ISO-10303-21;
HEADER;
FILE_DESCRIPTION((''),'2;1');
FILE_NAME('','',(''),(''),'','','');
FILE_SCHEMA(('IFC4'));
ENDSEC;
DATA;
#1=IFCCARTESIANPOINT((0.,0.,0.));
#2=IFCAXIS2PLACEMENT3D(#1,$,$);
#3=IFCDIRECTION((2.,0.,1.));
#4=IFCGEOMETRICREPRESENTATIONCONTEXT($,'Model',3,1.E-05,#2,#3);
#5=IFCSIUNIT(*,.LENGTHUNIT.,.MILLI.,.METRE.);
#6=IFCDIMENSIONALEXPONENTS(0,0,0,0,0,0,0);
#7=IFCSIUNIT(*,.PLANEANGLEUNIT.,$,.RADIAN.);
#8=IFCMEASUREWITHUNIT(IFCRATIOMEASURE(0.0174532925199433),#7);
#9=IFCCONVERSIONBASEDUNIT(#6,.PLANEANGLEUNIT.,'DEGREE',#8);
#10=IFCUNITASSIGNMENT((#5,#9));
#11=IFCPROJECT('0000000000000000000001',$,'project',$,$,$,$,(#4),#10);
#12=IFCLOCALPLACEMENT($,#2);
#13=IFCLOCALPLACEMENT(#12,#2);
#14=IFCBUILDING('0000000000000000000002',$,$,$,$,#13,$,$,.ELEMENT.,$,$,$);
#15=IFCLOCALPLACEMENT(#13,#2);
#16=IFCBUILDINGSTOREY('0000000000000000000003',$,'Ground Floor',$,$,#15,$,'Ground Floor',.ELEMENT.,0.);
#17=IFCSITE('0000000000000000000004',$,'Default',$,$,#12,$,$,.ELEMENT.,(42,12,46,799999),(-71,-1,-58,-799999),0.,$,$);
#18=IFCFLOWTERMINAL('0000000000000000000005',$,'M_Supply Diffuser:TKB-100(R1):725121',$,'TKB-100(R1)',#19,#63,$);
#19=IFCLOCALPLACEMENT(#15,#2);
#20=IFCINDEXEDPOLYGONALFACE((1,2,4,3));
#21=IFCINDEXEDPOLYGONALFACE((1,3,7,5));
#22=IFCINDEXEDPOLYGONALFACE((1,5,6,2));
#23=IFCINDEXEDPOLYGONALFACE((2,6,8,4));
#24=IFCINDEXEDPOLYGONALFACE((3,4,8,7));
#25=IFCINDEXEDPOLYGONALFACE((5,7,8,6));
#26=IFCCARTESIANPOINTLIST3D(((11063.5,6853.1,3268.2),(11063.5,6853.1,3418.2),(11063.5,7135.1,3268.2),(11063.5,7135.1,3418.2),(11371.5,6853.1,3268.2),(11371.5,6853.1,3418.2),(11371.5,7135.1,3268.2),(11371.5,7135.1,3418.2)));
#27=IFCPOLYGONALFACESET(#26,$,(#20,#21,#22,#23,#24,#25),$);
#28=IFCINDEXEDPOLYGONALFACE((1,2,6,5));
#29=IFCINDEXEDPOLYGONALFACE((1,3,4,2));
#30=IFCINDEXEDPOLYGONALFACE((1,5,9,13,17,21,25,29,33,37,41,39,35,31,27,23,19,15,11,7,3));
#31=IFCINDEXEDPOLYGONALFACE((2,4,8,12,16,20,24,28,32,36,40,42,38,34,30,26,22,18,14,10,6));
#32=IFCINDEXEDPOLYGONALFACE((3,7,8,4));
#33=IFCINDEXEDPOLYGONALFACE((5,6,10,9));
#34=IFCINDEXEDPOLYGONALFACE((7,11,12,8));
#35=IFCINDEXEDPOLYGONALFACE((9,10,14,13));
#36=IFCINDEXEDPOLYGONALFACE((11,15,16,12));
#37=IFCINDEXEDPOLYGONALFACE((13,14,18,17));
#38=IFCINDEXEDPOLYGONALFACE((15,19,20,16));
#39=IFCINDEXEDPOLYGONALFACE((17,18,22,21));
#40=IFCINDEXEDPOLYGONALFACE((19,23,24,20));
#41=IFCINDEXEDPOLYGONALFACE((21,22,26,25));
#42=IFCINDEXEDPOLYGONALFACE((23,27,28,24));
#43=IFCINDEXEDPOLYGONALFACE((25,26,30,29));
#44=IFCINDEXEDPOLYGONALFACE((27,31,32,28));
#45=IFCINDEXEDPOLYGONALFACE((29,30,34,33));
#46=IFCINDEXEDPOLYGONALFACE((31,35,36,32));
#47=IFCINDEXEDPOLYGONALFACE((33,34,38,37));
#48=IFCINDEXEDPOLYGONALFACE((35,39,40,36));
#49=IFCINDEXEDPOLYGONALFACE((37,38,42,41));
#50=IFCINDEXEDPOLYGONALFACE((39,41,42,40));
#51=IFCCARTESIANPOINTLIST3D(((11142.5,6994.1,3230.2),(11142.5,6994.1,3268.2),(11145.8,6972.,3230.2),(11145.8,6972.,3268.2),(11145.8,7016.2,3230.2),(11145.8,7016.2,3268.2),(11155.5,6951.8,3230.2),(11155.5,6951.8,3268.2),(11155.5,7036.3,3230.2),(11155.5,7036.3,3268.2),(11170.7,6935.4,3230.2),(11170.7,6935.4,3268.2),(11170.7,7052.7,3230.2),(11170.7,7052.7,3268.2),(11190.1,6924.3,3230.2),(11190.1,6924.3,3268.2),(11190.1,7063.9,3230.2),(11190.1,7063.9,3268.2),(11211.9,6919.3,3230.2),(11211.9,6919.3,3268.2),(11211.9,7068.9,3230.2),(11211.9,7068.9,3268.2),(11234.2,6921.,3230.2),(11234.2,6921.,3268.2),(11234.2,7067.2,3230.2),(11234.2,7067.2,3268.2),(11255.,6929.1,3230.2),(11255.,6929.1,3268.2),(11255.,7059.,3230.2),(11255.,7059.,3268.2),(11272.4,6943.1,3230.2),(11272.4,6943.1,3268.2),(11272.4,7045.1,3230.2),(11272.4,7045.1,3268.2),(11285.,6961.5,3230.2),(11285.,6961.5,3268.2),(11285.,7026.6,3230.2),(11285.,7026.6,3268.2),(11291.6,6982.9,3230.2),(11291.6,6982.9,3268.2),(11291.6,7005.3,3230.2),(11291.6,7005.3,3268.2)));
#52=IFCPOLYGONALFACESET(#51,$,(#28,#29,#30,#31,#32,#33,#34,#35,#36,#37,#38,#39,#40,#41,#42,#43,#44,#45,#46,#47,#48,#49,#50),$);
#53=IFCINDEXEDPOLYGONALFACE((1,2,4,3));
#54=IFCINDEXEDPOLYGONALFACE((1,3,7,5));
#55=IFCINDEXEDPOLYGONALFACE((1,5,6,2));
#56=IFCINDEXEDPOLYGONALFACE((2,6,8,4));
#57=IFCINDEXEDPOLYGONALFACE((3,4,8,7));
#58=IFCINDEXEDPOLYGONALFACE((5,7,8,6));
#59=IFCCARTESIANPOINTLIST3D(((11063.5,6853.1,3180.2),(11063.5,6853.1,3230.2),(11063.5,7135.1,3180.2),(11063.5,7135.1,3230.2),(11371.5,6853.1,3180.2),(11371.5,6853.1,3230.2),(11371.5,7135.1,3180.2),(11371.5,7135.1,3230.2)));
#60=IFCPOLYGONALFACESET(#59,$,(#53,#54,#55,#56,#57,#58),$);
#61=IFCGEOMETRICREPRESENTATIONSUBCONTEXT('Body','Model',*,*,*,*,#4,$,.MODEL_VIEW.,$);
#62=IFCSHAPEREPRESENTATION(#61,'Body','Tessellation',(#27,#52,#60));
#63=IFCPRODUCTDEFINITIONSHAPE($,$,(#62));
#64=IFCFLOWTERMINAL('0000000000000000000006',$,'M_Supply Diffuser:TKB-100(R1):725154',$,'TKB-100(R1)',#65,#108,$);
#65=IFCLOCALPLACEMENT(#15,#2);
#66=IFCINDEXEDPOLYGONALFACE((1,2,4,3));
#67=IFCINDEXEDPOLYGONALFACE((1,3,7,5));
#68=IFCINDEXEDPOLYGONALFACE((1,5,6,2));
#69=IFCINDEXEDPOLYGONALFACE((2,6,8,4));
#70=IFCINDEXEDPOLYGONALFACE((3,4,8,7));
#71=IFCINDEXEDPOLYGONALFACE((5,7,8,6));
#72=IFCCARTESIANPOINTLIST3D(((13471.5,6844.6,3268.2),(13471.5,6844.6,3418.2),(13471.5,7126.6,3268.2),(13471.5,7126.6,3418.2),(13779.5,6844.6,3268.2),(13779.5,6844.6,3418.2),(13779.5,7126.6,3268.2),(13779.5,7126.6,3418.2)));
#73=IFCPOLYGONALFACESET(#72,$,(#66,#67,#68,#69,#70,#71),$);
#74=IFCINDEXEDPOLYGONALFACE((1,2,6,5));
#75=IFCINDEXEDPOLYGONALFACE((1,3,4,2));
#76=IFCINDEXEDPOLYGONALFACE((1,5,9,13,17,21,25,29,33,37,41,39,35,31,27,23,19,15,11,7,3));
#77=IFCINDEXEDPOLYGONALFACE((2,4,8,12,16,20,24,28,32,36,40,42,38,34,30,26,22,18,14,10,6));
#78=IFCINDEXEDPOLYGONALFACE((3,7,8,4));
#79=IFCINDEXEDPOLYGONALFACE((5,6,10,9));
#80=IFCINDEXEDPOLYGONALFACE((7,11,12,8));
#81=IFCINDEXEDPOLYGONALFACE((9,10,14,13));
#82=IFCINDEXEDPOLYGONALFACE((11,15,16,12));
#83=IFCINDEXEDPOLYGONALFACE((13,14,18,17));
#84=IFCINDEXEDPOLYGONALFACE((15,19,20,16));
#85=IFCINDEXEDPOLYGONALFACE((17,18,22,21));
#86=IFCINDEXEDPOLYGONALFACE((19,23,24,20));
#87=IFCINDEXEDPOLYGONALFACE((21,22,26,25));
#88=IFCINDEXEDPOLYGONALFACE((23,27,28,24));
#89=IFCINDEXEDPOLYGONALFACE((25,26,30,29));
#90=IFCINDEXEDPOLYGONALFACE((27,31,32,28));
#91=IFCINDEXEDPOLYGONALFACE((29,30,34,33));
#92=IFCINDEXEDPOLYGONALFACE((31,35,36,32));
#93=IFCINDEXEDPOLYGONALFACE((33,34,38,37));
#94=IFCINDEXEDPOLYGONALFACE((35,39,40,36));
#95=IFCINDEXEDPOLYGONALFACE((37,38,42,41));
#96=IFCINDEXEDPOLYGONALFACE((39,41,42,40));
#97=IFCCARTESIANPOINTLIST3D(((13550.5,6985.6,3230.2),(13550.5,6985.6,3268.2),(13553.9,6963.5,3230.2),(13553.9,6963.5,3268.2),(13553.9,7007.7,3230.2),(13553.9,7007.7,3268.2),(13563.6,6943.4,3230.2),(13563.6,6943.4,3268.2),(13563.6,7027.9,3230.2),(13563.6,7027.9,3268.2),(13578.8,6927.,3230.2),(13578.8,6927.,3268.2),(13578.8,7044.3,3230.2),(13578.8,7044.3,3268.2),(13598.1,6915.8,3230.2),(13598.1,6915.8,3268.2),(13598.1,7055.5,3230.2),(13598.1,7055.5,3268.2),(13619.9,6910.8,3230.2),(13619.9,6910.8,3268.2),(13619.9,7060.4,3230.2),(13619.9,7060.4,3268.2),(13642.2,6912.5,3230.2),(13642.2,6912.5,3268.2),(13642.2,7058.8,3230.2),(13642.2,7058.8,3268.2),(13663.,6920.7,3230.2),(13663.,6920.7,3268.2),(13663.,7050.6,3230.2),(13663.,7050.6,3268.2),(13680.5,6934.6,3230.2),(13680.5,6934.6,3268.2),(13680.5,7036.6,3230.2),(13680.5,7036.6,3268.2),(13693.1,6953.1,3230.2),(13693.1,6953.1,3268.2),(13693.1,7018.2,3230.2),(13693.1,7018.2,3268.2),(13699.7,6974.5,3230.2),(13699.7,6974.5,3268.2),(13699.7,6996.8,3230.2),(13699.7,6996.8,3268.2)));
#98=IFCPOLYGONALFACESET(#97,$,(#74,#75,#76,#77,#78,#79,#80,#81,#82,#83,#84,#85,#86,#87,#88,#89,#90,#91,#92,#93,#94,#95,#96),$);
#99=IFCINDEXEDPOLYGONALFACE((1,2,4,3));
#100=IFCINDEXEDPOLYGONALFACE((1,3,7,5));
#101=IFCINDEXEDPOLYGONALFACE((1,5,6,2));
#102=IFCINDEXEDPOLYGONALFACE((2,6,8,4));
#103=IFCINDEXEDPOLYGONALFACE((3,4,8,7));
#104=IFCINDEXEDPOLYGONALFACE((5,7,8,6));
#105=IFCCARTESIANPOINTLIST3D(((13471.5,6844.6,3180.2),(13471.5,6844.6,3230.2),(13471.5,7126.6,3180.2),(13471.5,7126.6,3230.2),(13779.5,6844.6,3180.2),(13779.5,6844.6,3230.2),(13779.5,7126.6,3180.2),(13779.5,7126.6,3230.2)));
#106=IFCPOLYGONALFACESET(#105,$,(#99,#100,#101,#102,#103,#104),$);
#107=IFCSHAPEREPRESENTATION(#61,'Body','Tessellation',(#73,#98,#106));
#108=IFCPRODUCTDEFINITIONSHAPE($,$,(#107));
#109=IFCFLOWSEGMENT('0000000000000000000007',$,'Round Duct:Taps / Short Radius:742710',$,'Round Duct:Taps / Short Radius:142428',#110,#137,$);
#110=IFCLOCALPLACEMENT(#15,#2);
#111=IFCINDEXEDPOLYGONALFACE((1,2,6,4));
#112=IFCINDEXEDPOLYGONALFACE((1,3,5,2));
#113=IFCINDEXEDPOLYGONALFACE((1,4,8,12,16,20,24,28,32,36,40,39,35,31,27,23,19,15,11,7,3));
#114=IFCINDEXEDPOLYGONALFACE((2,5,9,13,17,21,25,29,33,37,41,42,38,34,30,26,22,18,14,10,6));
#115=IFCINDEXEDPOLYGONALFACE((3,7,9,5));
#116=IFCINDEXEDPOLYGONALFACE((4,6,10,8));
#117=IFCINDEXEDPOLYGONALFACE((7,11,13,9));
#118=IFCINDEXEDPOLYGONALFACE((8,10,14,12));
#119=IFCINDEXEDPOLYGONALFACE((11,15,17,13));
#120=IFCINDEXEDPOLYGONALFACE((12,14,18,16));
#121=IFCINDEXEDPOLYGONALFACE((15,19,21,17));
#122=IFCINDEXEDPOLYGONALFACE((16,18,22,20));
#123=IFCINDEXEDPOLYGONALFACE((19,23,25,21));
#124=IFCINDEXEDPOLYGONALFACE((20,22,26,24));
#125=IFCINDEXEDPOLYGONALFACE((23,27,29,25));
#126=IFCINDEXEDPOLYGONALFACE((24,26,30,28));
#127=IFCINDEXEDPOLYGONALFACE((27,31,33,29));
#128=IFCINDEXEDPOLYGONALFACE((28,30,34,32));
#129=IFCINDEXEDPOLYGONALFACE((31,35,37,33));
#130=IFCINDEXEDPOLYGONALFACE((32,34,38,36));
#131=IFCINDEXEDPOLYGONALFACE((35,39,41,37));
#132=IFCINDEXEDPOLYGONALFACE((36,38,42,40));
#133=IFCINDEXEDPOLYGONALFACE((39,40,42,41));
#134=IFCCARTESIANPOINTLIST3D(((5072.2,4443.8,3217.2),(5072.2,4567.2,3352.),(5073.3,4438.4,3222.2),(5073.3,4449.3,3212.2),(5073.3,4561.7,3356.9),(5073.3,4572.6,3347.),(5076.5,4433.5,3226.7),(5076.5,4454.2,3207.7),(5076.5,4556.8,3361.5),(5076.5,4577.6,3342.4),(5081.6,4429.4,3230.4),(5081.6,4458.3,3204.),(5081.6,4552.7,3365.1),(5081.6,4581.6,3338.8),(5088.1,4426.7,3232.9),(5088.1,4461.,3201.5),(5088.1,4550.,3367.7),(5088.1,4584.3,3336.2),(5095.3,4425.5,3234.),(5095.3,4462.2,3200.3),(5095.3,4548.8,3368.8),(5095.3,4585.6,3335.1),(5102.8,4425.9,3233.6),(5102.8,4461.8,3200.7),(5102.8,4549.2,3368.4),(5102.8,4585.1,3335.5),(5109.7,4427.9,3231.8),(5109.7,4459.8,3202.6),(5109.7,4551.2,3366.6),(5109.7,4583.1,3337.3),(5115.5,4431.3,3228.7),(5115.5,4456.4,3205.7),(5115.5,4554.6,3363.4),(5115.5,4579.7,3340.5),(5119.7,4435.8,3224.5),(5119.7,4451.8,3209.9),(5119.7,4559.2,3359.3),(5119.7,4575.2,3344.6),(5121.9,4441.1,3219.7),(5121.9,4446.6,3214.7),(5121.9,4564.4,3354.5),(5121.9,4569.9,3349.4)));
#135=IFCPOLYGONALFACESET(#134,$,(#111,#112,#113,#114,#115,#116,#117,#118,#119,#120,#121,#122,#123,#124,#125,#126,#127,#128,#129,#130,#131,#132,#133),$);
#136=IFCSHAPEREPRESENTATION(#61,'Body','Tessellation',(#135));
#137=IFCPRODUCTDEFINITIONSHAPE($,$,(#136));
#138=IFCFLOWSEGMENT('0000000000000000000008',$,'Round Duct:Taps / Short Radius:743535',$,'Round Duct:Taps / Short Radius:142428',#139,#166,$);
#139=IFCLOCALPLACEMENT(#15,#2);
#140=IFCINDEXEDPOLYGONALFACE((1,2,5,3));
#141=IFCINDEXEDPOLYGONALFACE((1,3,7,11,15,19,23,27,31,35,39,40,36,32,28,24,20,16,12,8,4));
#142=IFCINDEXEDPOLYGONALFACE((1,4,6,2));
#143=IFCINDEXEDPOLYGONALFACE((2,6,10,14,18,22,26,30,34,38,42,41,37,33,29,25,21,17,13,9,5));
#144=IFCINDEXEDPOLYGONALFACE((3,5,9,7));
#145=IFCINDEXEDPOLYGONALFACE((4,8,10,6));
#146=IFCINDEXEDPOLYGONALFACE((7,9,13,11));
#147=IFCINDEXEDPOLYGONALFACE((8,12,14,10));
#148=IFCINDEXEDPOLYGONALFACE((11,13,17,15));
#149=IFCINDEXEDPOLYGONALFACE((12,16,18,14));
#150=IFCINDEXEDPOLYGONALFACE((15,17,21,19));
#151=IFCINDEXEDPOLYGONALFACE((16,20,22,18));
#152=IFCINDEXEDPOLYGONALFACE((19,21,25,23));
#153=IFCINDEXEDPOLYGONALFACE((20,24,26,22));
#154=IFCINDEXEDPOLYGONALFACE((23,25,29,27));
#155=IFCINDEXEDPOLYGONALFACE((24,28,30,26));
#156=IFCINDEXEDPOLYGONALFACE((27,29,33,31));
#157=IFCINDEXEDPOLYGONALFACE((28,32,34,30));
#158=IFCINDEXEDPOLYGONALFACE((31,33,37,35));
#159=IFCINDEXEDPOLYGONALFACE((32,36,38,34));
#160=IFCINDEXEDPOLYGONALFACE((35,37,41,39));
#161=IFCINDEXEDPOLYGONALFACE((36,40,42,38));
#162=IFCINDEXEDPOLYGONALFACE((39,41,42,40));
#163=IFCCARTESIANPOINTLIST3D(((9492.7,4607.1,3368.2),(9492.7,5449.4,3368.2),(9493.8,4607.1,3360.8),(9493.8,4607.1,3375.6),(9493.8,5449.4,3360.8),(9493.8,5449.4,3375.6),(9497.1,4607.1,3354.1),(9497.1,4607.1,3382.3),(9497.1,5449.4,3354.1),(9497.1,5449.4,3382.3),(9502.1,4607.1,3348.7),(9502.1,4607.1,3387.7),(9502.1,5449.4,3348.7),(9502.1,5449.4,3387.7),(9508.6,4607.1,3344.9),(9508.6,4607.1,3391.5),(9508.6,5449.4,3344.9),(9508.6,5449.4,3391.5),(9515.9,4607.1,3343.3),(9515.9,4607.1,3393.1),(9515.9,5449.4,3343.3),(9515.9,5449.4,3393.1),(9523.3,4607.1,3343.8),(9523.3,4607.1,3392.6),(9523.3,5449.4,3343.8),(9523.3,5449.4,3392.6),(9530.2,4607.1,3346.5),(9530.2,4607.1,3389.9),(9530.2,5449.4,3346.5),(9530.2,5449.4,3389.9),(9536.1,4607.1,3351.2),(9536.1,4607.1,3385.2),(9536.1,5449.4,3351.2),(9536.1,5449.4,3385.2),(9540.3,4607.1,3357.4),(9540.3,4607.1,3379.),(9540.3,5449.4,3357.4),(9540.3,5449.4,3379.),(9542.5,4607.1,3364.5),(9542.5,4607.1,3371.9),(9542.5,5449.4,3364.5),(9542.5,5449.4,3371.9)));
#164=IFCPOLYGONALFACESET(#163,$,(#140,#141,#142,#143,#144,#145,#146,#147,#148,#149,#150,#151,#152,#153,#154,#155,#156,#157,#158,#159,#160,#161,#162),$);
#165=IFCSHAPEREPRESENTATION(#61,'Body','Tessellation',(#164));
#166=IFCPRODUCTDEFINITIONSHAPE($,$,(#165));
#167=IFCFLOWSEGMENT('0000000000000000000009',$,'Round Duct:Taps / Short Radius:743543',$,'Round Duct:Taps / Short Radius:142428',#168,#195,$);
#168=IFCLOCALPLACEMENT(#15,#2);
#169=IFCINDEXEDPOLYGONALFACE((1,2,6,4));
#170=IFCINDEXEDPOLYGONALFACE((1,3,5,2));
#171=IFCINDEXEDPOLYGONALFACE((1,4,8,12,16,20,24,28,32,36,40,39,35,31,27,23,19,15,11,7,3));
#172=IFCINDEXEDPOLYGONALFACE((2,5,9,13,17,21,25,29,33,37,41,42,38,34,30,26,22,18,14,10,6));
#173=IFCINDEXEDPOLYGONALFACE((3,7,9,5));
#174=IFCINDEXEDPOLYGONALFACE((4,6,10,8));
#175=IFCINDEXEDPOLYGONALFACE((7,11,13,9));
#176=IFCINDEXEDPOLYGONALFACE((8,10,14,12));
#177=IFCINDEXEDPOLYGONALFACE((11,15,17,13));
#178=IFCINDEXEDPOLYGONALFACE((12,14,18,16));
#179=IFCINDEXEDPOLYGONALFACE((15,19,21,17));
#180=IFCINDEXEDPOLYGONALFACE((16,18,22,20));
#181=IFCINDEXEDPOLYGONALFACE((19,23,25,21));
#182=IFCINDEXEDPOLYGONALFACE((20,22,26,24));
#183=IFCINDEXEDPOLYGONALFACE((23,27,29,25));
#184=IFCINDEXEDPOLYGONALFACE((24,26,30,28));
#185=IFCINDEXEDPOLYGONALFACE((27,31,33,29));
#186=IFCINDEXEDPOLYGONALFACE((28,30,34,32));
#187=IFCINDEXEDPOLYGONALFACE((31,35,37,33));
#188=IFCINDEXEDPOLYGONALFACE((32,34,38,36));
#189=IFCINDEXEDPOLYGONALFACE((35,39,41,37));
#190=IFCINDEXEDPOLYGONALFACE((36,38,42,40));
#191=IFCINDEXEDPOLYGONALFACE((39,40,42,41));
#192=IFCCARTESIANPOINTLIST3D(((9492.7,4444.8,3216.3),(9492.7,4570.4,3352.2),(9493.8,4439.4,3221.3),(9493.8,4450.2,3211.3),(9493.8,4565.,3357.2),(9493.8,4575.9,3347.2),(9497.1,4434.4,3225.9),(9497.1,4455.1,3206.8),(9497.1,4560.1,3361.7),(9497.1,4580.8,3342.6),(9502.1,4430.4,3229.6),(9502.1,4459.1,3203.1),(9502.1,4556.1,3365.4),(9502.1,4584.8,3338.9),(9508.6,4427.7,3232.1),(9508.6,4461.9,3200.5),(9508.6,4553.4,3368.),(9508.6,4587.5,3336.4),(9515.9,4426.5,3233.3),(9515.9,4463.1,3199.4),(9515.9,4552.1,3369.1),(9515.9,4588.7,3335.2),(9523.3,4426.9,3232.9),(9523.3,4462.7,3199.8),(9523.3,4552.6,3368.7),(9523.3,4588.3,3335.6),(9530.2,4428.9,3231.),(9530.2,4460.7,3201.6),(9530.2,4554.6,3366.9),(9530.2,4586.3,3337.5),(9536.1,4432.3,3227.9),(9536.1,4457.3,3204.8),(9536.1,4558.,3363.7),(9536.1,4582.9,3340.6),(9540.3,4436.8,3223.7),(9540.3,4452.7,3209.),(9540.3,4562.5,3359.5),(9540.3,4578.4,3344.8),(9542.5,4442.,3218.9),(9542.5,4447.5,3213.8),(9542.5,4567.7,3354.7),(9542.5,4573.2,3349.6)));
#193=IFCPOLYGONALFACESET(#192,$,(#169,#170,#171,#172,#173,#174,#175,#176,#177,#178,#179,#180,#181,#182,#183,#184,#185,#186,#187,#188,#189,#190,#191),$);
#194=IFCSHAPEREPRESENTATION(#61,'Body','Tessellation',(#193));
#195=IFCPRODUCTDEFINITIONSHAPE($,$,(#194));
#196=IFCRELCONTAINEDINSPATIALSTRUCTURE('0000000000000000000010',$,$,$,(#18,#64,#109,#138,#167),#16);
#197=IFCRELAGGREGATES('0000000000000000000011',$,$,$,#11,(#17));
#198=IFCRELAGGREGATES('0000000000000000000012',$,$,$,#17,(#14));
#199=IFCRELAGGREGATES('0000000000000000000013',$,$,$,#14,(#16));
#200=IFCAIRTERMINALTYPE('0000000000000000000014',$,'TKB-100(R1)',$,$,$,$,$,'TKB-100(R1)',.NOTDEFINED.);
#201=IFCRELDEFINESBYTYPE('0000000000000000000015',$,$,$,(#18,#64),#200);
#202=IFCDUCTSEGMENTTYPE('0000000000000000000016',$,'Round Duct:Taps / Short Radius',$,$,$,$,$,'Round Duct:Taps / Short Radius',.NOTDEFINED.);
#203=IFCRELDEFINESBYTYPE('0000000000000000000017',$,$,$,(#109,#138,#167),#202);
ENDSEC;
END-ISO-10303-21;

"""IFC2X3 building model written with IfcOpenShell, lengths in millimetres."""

from ifc_helpers import new_model, entity, si_unit, converted_unit, direction, frame, frame_2d, origin, origin_2d_with_axis, place, context, subcontext, project, spatial, rectangle, circle, extrude, source, transform, mapped, type_object, type_shapes, element, save


model = new_model("IFC2X3")

# Units and contexts
model_context = context("Model", 3, precision=1e-05, world=origin(), true_north=direction((2.0, 0.0, 1.0)))
body_context = subcontext(model_context, "Body", "Model", "MODEL_VIEW")
ifc_project = project(units=[si_unit("LENGTHUNIT", "METRE", prefix="MILLI"), converted_unit("PLANEANGLEUNIT", "DEGREE", entity("IfcRatioMeasure", 0.0174532925199433), si_unit("PLANEANGLEUNIT", "RADIAN"), dimensions=[0, 0, 0, 0, 0, 0, 0])], contexts=[model_context])

# Site, building, storey
site_placement = place(None, origin())
site = spatial("IfcSite", under=ifc_project, at=site_placement, Name="Default", CompositionType="ELEMENT", RefLatitude=(42, 12, 46, 799999), RefLongitude=(-71, -1, -58, -799999), RefElevation=0.0)
building_placement = place(site_placement, origin())
building = spatial("IfcBuilding", under=site, at=building_placement, CompositionType="ELEMENT")
storey_placement = place(building_placement, origin())
storey = spatial("IfcBuildingStorey", under=building, at=storey_placement, Name="Ground Floor", LongName="Ground Floor", CompositionType="ELEMENT", Elevation=0.0)

# Flow terminals
air_terminal_type_1 = type_object("IfcAirTerminalType", Name="TKB-100(R1)", ElementType="TKB-100(R1)", PredefinedType="NOTDEFINED")
shared_shape_1 = source(origin(), body_context, "Body", "SweptSolid", [
    extrude(rectangle(XDim=308.0, YDim=282.0, at=origin_2d_with_axis()), frame((0.0, 0.0, 88.0), z_axis=(0.0, 0.0, 1.0), x_axis=(-1.0, 0.0, 0.0)), (0.0, 0.0, 1.0), 150.0),
    extrude(circle(Radius=75.0, at=frame_2d((0.0, 0.0), x_axis=(1.0, 0.0))), frame((0.0, 0.0, 50.0)), (0.0, 0.0, 1.0), 38.0),
    extrude(rectangle(XDim=282.0, YDim=308.0, at=origin_2d_with_axis()), frame((0.0, 0.0, 0.0), z_axis=(0.0, 0.0, 1.0), x_axis=(0.0, 1.0, 0.0)), (0.0, 0.0, 1.0), 50.0),
])
type_shapes(air_terminal_type_1, [shared_shape_1])
for number, where, z_axis, x_axis, name in (
    (1, (11217.5, 6994.1, 3180.2), (0.0, 0.0, 1.0), (-1.0, 0.0, 0.0), "M_Supply Diffuser:TKB-100(R1):725121"),
    (2, (13625.5, 6985.6, 3180.2), (0.0, 0.0, 1.0), (-1.0, 0.0, 0.0), "M_Supply Diffuser:TKB-100(R1):725154"),
):
    element("IfcFlowTerminal", number, at=place(storey_placement, frame(where, z_axis=z_axis, x_axis=x_axis)), inside=storey, type_object=air_terminal_type_1, Name=name, ObjectType="TKB-100(R1)", context=body_context, shape_type="MappedRepresentation", body=[
        mapped(shared_shape_1, transform((0.0, 0.0, 0.0), scale=1.0)),
    ])

# Flow segments
duct_segment_type = type_object("IfcDuctSegmentType", Name="Round Duct:Taps / Short Radius", ElementType="Round Duct:Taps / Short Radius", PredefinedType="NOTDEFINED")
flow_segment_1_placement = place(storey_placement, origin())
element("IfcFlowSegment", 3, at=flow_segment_1_placement, inside=storey, type_object=duct_segment_type, Name="Round Duct:Taps / Short Radius:742710", ObjectType="Round Duct:Taps / Short Radius:142428", context=body_context, shape_type="SweptSolid", body=[
    extrude(circle(Radius=25.0, at=frame_2d((0.0, 0.0), x_axis=(1.0, 0.0))), frame((5097.2, 4443.8, 3217.2), z_axis=(0.0, 0.675064, 0.737759), x_axis=(-1.0, 0.0, 0.0)), (0.0, 0.0, 1.0), 182.7),
])
flow_segment_2_placement = place(storey_placement, origin())
element("IfcFlowSegment", 4, at=flow_segment_2_placement, inside=storey, type_object=duct_segment_type, Name="Round Duct:Taps / Short Radius:743535", ObjectType="Round Duct:Taps / Short Radius:142428", context=body_context, shape_type="SweptSolid", body=[
    extrude(circle(Radius=25.0, at=frame_2d((0.0, 0.0), x_axis=(1.0, 0.0))), frame((9517.7, 4607.1, 3368.2), z_axis=(0.0, 1.0, 0.0), x_axis=(-1.0, 0.0, 0.0)), (0.0, 0.0, 1.0), 842.3),
])
flow_segment_3_placement = place(storey_placement, origin())
element("IfcFlowSegment", 5, at=flow_segment_3_placement, inside=storey, type_object=duct_segment_type, Name="Round Duct:Taps / Short Radius:743543", ObjectType="Round Duct:Taps / Short Radius:142428", context=body_context, shape_type="SweptSolid", body=[
    extrude(circle(Radius=25.0, at=frame_2d((0.0, 0.0), x_axis=(1.0, 0.0))), frame((9517.7, 4444.8, 3216.3), z_axis=(0.0, 0.679145, 0.734004), x_axis=(-1.0, 0.0, 0.0)), (0.0, 0.0, 1.0), 185.1),
])

save(model, "model.ifc")
